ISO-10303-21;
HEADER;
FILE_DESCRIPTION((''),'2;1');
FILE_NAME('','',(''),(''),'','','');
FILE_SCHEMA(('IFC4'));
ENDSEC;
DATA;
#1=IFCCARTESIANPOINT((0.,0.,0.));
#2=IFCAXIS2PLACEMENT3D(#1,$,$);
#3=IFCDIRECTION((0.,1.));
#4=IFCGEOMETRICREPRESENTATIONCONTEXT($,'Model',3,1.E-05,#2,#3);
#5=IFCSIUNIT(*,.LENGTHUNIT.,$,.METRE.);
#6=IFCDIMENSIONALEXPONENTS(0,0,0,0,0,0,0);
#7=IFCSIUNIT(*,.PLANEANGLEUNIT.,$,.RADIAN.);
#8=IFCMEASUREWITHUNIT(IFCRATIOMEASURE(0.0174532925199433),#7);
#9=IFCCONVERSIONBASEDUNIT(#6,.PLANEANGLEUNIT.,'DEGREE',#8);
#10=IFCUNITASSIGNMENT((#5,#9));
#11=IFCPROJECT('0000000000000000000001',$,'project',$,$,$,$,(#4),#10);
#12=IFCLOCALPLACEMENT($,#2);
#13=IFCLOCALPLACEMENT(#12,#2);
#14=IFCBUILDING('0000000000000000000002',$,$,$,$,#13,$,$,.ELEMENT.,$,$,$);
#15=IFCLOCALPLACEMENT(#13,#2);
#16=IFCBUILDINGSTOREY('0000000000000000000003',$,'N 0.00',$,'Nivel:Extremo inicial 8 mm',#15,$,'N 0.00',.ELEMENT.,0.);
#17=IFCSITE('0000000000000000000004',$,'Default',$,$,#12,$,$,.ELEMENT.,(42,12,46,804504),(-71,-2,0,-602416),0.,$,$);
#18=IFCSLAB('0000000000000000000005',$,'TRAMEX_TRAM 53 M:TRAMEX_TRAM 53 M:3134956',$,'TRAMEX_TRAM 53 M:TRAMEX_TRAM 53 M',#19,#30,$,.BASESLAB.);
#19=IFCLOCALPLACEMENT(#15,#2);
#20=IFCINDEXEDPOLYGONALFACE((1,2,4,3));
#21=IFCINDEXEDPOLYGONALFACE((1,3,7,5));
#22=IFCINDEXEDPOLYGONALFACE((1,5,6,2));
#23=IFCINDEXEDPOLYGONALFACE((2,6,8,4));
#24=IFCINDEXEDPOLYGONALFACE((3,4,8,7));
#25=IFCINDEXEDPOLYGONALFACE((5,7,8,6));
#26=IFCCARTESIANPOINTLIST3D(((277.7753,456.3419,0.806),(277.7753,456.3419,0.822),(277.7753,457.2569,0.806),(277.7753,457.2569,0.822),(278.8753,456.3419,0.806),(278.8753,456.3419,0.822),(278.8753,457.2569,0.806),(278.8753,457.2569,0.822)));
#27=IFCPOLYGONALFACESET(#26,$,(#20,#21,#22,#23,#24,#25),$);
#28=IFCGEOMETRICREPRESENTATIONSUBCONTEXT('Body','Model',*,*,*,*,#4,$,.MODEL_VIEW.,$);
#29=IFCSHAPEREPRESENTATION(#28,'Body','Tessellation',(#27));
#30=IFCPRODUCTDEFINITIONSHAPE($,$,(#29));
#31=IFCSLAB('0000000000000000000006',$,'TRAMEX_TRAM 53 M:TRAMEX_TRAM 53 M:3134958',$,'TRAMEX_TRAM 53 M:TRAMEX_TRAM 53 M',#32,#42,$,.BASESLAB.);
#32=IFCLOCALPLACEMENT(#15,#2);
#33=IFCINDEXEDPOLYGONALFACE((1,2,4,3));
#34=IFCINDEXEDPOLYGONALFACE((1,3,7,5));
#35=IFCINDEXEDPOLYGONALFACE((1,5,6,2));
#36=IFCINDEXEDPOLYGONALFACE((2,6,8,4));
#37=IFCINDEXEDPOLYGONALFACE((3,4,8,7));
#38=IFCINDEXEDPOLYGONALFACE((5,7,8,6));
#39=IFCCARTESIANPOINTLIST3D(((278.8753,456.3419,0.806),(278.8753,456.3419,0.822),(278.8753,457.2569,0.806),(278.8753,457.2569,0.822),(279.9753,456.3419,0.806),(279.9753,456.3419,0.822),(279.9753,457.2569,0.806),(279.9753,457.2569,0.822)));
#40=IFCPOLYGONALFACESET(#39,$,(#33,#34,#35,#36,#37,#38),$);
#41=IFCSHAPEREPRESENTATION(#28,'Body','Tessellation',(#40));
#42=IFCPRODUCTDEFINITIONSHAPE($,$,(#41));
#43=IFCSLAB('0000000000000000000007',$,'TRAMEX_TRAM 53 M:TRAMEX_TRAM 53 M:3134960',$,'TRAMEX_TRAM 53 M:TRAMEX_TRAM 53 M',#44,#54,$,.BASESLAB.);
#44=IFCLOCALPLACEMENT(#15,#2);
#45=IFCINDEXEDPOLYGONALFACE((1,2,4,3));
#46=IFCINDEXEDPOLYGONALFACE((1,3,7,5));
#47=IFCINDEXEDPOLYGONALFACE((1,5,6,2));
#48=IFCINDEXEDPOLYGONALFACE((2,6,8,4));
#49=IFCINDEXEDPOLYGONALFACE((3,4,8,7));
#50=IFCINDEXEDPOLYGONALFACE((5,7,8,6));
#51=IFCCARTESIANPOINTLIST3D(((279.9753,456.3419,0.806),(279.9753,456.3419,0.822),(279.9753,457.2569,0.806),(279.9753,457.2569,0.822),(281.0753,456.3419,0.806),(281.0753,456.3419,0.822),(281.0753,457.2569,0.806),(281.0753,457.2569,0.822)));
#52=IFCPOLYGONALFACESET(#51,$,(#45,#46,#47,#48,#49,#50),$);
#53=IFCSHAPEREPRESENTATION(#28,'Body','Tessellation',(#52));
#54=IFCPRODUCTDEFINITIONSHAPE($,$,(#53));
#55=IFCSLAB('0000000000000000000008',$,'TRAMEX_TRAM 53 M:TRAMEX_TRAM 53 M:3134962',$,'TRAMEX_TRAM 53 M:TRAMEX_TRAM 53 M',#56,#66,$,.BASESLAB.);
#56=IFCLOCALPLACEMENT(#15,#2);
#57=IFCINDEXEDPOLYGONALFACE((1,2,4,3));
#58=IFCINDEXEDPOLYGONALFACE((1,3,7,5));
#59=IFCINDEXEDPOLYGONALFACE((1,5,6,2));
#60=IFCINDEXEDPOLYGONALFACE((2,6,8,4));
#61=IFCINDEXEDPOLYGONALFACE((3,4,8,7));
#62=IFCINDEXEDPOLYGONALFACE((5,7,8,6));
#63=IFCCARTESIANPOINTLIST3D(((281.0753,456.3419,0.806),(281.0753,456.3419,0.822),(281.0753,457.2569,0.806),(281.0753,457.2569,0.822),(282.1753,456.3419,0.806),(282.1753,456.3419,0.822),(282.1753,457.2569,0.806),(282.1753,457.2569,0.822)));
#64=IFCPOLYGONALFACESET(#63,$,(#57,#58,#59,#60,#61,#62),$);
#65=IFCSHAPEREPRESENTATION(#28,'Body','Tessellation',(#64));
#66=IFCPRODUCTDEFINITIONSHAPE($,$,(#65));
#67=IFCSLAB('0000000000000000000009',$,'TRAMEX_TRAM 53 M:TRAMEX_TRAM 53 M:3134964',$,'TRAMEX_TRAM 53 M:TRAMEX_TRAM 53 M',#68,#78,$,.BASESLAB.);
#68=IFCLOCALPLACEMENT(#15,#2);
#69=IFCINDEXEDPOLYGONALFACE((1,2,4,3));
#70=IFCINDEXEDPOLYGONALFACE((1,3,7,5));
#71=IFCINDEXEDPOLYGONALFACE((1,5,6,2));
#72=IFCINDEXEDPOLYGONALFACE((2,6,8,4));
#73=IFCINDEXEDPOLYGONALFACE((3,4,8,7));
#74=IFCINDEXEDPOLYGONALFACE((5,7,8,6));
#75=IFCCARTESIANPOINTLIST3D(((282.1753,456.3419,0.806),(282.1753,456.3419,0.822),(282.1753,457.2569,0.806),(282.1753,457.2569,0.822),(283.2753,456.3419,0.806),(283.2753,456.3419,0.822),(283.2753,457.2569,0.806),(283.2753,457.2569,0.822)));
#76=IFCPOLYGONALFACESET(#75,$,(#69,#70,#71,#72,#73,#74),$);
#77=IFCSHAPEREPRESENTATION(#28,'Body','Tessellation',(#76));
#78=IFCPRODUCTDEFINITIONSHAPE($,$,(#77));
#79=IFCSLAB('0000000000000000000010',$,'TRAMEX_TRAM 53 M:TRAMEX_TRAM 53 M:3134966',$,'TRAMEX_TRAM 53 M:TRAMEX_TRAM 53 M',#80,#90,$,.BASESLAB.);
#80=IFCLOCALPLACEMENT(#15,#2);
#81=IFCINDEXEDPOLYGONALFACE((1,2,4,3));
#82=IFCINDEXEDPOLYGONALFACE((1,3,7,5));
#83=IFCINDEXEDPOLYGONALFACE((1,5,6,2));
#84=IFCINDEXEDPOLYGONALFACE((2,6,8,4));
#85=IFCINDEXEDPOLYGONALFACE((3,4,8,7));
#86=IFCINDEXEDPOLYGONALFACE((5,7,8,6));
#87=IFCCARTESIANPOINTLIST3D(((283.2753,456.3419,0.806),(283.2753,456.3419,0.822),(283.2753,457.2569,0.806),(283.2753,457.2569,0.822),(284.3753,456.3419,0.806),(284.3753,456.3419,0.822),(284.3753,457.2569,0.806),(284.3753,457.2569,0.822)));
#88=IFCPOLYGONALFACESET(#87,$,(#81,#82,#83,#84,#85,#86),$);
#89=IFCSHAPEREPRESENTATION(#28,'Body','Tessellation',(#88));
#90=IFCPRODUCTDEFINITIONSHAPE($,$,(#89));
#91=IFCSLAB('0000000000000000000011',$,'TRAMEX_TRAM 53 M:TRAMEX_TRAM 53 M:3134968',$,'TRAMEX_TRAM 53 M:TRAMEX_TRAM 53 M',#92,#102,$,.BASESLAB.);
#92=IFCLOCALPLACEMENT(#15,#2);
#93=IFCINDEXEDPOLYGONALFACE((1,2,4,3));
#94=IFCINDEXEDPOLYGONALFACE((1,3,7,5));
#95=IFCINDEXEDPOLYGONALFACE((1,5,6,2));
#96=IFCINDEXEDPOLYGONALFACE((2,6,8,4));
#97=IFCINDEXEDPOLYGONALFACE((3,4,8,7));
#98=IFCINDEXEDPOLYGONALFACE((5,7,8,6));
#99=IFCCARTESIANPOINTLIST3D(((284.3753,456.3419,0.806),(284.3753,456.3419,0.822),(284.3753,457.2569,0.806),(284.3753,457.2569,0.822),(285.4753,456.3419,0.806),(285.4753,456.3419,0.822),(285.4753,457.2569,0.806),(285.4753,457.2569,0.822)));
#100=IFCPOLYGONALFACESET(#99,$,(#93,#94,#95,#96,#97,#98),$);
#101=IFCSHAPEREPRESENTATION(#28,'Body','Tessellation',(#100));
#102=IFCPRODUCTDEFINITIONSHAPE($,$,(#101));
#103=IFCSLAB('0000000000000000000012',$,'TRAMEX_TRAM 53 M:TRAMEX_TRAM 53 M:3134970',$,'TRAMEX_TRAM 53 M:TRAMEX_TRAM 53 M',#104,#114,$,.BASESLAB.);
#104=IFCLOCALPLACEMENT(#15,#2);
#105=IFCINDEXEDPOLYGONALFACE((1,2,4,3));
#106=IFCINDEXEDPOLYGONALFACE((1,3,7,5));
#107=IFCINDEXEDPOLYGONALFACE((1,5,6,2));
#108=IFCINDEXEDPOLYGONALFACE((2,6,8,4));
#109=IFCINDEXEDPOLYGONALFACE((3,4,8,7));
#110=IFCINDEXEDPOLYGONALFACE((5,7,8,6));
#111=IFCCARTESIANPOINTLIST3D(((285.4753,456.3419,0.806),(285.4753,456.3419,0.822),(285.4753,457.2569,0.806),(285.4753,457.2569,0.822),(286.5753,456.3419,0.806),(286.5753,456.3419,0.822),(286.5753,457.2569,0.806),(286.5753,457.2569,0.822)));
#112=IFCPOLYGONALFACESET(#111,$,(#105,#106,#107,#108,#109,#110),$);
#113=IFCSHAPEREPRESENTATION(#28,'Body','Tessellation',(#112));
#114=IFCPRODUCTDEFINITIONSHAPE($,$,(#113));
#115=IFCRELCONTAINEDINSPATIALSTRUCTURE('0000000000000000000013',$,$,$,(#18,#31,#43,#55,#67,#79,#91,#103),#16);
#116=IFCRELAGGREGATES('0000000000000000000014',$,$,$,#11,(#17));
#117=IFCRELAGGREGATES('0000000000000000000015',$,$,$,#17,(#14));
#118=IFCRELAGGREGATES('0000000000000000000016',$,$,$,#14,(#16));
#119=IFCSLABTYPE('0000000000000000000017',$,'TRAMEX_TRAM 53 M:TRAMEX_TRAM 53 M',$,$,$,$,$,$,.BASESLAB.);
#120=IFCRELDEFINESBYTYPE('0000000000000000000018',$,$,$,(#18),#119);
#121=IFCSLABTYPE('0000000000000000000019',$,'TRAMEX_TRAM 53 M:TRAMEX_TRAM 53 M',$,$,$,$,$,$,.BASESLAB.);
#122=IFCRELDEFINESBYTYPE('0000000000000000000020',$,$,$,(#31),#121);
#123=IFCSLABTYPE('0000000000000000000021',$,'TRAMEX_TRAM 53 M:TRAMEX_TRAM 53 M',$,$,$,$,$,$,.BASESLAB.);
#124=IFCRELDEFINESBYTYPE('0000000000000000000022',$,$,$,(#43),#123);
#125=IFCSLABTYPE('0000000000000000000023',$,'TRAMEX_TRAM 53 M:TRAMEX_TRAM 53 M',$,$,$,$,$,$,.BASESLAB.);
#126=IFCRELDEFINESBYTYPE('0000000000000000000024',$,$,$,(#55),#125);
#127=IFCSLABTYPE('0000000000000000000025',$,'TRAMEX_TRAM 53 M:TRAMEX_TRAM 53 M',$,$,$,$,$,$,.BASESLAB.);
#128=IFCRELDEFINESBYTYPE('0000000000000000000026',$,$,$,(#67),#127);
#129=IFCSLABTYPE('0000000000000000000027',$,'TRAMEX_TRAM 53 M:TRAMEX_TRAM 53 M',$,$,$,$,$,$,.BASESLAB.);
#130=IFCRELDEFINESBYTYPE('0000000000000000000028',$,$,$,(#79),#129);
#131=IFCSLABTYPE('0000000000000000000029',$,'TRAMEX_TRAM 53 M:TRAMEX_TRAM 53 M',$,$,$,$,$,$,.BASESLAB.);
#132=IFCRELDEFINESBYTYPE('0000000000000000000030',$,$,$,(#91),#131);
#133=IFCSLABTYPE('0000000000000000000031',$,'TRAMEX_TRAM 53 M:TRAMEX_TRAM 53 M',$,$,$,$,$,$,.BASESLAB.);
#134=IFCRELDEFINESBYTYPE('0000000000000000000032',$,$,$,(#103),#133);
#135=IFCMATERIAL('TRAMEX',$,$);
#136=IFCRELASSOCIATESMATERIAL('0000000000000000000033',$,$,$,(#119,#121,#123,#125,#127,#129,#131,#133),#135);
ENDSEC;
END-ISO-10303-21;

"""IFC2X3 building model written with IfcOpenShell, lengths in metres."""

from ifc_helpers import new_model, entity, si_unit, converted_unit, direction, frame, frame_2d, origin, place, context, subcontext, project, spatial, rectangle, extrude, material, type_object, element, save


model = new_model("IFC2X3")

# Units and contexts
model_context = context("Model", 3, precision=1e-05, world=origin(), true_north=direction((0.0, 1.0)))
body_context = subcontext(model_context, "Body", "Model", "MODEL_VIEW")
ifc_project = project(units=[si_unit("LENGTHUNIT", "METRE"), converted_unit("PLANEANGLEUNIT", "DEGREE", entity("IfcRatioMeasure", 0.0174532925199433), si_unit("PLANEANGLEUNIT", "RADIAN"), dimensions=[0, 0, 0, 0, 0, 0, 0])], contexts=[model_context])

# Site, building, storey
site_placement = place(None, origin())
site = spatial("IfcSite", under=ifc_project, at=site_placement, Name="Default", CompositionType="ELEMENT", RefLatitude=(42, 12, 46, 804504), RefLongitude=(-71, -2, 0, -602416), RefElevation=0.0)
building_placement = place(site_placement, origin())
building = spatial("IfcBuilding", under=site, at=building_placement, CompositionType="ELEMENT")
storey_placement = place(building_placement, origin())
storey = spatial("IfcBuildingStorey", under=building, at=storey_placement, Name="N 0.00", ObjectType="Nivel:Extremo inicial 8 mm", LongName="N 0.00", CompositionType="ELEMENT", Elevation=0.0)

# Slabs
ifc_material = material(Name="TRAMEX")
slab_type_1 = type_object("IfcSlabType", Name="TRAMEX_TRAM 53 M:TRAMEX_TRAM 53 M", PredefinedType="BASESLAB", material=ifc_material)
slab_1_placement = place(storey_placement, origin())
element("IfcSlab", 1, at=slab_1_placement, inside=storey, type_object=slab_type_1, Name="TRAMEX_TRAM 53 M:TRAMEX_TRAM 53 M:3134956", ObjectType="TRAMEX_TRAM 53 M:TRAMEX_TRAM 53 M", PredefinedType="BASESLAB", context=body_context, shape_type="SweptSolid", body=[
    extrude(rectangle(XDim=1.1, YDim=0.915, at=frame_2d((0.0, 0.0), x_axis=(1.0, 0.0))), frame((278.3253, 456.7994, 0.806), z_axis=(0.0, 0.0, 1.0), x_axis=(-1.0, 0.0, 0.0)), (0.0, 0.0, 1.0), 0.016),
])
slab_type_2 = type_object("IfcSlabType", Name="TRAMEX_TRAM 53 M:TRAMEX_TRAM 53 M", PredefinedType="BASESLAB", material=ifc_material)
slab_2_placement = place(storey_placement, origin())
element("IfcSlab", 2, at=slab_2_placement, inside=storey, type_object=slab_type_2, Name="TRAMEX_TRAM 53 M:TRAMEX_TRAM 53 M:3134958", ObjectType="TRAMEX_TRAM 53 M:TRAMEX_TRAM 53 M", PredefinedType="BASESLAB", context=body_context, shape_type="SweptSolid", body=[
    extrude(rectangle(XDim=1.1, YDim=0.915, at=frame_2d((0.0, 0.0), x_axis=(1.0, 0.0))), frame((279.4253, 456.7994, 0.806), z_axis=(0.0, 0.0, 1.0), x_axis=(-1.0, 0.0, 0.0)), (0.0, 0.0, 1.0), 0.016),
])
slab_type_3 = type_object("IfcSlabType", Name="TRAMEX_TRAM 53 M:TRAMEX_TRAM 53 M", PredefinedType="BASESLAB", material=ifc_material)
slab_3_placement = place(storey_placement, origin())
element("IfcSlab", 3, at=slab_3_placement, inside=storey, type_object=slab_type_3, Name="TRAMEX_TRAM 53 M:TRAMEX_TRAM 53 M:3134960", ObjectType="TRAMEX_TRAM 53 M:TRAMEX_TRAM 53 M", PredefinedType="BASESLAB", context=body_context, shape_type="SweptSolid", body=[
    extrude(rectangle(XDim=1.1, YDim=0.915, at=frame_2d((0.0, 0.0), x_axis=(1.0, 0.0))), frame((280.5253, 456.7994, 0.806), z_axis=(0.0, 0.0, 1.0), x_axis=(-1.0, 0.0, 0.0)), (0.0, 0.0, 1.0), 0.016),
])
slab_type_4 = type_object("IfcSlabType", Name="TRAMEX_TRAM 53 M:TRAMEX_TRAM 53 M", PredefinedType="BASESLAB", material=ifc_material)
slab_4_placement = place(storey_placement, origin())
element("IfcSlab", 4, at=slab_4_placement, inside=storey, type_object=slab_type_4, Name="TRAMEX_TRAM 53 M:TRAMEX_TRAM 53 M:3134962", ObjectType="TRAMEX_TRAM 53 M:TRAMEX_TRAM 53 M", PredefinedType="BASESLAB", context=body_context, shape_type="SweptSolid", body=[
    extrude(rectangle(XDim=1.1, YDim=0.915, at=frame_2d((0.0, 0.0), x_axis=(1.0, 0.0))), frame((281.6253, 456.7994, 0.806), z_axis=(0.0, 0.0, 1.0), x_axis=(-1.0, 0.0, 0.0)), (0.0, 0.0, 1.0), 0.016),
])
slab_type_5 = type_object("IfcSlabType", Name="TRAMEX_TRAM 53 M:TRAMEX_TRAM 53 M", PredefinedType="BASESLAB", material=ifc_material)
slab_5_placement = place(storey_placement, origin())
element("IfcSlab", 5, at=slab_5_placement, inside=storey, type_object=slab_type_5, Name="TRAMEX_TRAM 53 M:TRAMEX_TRAM 53 M:3134964", ObjectType="TRAMEX_TRAM 53 M:TRAMEX_TRAM 53 M", PredefinedType="BASESLAB", context=body_context, shape_type="SweptSolid", body=[
    extrude(rectangle(XDim=1.1, YDim=0.915, at=frame_2d((0.0, 0.0), x_axis=(1.0, 0.0))), frame((282.7253, 456.7994, 0.806), z_axis=(0.0, 0.0, 1.0), x_axis=(-1.0, 0.0, 0.0)), (0.0, 0.0, 1.0), 0.016),
])
slab_type_6 = type_object("IfcSlabType", Name="TRAMEX_TRAM 53 M:TRAMEX_TRAM 53 M", PredefinedType="BASESLAB", material=ifc_material)
slab_6_placement = place(storey_placement, origin())
element("IfcSlab", 6, at=slab_6_placement, inside=storey, type_object=slab_type_6, Name="TRAMEX_TRAM 53 M:TRAMEX_TRAM 53 M:3134966", ObjectType="TRAMEX_TRAM 53 M:TRAMEX_TRAM 53 M", PredefinedType="BASESLAB", context=body_context, shape_type="SweptSolid", body=[
    extrude(rectangle(XDim=1.1, YDim=0.915, at=frame_2d((0.0, 0.0), x_axis=(1.0, 0.0))), frame((283.8253, 456.7994, 0.806), z_axis=(0.0, 0.0, 1.0), x_axis=(-1.0, 0.0, 0.0)), (0.0, 0.0, 1.0), 0.016),
])
slab_type_7 = type_object("IfcSlabType", Name="TRAMEX_TRAM 53 M:TRAMEX_TRAM 53 M", PredefinedType="BASESLAB", material=ifc_material)
slab_7_placement = place(storey_placement, origin())
element("IfcSlab", 7, at=slab_7_placement, inside=storey, type_object=slab_type_7, Name="TRAMEX_TRAM 53 M:TRAMEX_TRAM 53 M:3134968", ObjectType="TRAMEX_TRAM 53 M:TRAMEX_TRAM 53 M", PredefinedType="BASESLAB", context=body_context, shape_type="SweptSolid", body=[
    extrude(rectangle(XDim=1.1, YDim=0.915, at=frame_2d((0.0, 0.0), x_axis=(1.0, 0.0))), frame((284.9253, 456.7994, 0.806), z_axis=(0.0, 0.0, 1.0), x_axis=(-1.0, 0.0, 0.0)), (0.0, 0.0, 1.0), 0.016),
])
slab_type_8 = type_object("IfcSlabType", Name="TRAMEX_TRAM 53 M:TRAMEX_TRAM 53 M", PredefinedType="BASESLAB", material=ifc_material)
slab_8_placement = place(storey_placement, origin())
element("IfcSlab", 8, at=slab_8_placement, inside=storey, type_object=slab_type_8, Name="TRAMEX_TRAM 53 M:TRAMEX_TRAM 53 M:3134970", ObjectType="TRAMEX_TRAM 53 M:TRAMEX_TRAM 53 M", PredefinedType="BASESLAB", context=body_context, shape_type="SweptSolid", body=[
    extrude(rectangle(XDim=1.1, YDim=0.915, at=frame_2d((0.0, 0.0), x_axis=(1.0, 0.0))), frame((286.0253, 456.7994, 0.806), z_axis=(0.0, 0.0, 1.0), x_axis=(-1.0, 0.0, 0.0)), (0.0, 0.0, 1.0), 0.016),
])

save(model, "model.ifc")
